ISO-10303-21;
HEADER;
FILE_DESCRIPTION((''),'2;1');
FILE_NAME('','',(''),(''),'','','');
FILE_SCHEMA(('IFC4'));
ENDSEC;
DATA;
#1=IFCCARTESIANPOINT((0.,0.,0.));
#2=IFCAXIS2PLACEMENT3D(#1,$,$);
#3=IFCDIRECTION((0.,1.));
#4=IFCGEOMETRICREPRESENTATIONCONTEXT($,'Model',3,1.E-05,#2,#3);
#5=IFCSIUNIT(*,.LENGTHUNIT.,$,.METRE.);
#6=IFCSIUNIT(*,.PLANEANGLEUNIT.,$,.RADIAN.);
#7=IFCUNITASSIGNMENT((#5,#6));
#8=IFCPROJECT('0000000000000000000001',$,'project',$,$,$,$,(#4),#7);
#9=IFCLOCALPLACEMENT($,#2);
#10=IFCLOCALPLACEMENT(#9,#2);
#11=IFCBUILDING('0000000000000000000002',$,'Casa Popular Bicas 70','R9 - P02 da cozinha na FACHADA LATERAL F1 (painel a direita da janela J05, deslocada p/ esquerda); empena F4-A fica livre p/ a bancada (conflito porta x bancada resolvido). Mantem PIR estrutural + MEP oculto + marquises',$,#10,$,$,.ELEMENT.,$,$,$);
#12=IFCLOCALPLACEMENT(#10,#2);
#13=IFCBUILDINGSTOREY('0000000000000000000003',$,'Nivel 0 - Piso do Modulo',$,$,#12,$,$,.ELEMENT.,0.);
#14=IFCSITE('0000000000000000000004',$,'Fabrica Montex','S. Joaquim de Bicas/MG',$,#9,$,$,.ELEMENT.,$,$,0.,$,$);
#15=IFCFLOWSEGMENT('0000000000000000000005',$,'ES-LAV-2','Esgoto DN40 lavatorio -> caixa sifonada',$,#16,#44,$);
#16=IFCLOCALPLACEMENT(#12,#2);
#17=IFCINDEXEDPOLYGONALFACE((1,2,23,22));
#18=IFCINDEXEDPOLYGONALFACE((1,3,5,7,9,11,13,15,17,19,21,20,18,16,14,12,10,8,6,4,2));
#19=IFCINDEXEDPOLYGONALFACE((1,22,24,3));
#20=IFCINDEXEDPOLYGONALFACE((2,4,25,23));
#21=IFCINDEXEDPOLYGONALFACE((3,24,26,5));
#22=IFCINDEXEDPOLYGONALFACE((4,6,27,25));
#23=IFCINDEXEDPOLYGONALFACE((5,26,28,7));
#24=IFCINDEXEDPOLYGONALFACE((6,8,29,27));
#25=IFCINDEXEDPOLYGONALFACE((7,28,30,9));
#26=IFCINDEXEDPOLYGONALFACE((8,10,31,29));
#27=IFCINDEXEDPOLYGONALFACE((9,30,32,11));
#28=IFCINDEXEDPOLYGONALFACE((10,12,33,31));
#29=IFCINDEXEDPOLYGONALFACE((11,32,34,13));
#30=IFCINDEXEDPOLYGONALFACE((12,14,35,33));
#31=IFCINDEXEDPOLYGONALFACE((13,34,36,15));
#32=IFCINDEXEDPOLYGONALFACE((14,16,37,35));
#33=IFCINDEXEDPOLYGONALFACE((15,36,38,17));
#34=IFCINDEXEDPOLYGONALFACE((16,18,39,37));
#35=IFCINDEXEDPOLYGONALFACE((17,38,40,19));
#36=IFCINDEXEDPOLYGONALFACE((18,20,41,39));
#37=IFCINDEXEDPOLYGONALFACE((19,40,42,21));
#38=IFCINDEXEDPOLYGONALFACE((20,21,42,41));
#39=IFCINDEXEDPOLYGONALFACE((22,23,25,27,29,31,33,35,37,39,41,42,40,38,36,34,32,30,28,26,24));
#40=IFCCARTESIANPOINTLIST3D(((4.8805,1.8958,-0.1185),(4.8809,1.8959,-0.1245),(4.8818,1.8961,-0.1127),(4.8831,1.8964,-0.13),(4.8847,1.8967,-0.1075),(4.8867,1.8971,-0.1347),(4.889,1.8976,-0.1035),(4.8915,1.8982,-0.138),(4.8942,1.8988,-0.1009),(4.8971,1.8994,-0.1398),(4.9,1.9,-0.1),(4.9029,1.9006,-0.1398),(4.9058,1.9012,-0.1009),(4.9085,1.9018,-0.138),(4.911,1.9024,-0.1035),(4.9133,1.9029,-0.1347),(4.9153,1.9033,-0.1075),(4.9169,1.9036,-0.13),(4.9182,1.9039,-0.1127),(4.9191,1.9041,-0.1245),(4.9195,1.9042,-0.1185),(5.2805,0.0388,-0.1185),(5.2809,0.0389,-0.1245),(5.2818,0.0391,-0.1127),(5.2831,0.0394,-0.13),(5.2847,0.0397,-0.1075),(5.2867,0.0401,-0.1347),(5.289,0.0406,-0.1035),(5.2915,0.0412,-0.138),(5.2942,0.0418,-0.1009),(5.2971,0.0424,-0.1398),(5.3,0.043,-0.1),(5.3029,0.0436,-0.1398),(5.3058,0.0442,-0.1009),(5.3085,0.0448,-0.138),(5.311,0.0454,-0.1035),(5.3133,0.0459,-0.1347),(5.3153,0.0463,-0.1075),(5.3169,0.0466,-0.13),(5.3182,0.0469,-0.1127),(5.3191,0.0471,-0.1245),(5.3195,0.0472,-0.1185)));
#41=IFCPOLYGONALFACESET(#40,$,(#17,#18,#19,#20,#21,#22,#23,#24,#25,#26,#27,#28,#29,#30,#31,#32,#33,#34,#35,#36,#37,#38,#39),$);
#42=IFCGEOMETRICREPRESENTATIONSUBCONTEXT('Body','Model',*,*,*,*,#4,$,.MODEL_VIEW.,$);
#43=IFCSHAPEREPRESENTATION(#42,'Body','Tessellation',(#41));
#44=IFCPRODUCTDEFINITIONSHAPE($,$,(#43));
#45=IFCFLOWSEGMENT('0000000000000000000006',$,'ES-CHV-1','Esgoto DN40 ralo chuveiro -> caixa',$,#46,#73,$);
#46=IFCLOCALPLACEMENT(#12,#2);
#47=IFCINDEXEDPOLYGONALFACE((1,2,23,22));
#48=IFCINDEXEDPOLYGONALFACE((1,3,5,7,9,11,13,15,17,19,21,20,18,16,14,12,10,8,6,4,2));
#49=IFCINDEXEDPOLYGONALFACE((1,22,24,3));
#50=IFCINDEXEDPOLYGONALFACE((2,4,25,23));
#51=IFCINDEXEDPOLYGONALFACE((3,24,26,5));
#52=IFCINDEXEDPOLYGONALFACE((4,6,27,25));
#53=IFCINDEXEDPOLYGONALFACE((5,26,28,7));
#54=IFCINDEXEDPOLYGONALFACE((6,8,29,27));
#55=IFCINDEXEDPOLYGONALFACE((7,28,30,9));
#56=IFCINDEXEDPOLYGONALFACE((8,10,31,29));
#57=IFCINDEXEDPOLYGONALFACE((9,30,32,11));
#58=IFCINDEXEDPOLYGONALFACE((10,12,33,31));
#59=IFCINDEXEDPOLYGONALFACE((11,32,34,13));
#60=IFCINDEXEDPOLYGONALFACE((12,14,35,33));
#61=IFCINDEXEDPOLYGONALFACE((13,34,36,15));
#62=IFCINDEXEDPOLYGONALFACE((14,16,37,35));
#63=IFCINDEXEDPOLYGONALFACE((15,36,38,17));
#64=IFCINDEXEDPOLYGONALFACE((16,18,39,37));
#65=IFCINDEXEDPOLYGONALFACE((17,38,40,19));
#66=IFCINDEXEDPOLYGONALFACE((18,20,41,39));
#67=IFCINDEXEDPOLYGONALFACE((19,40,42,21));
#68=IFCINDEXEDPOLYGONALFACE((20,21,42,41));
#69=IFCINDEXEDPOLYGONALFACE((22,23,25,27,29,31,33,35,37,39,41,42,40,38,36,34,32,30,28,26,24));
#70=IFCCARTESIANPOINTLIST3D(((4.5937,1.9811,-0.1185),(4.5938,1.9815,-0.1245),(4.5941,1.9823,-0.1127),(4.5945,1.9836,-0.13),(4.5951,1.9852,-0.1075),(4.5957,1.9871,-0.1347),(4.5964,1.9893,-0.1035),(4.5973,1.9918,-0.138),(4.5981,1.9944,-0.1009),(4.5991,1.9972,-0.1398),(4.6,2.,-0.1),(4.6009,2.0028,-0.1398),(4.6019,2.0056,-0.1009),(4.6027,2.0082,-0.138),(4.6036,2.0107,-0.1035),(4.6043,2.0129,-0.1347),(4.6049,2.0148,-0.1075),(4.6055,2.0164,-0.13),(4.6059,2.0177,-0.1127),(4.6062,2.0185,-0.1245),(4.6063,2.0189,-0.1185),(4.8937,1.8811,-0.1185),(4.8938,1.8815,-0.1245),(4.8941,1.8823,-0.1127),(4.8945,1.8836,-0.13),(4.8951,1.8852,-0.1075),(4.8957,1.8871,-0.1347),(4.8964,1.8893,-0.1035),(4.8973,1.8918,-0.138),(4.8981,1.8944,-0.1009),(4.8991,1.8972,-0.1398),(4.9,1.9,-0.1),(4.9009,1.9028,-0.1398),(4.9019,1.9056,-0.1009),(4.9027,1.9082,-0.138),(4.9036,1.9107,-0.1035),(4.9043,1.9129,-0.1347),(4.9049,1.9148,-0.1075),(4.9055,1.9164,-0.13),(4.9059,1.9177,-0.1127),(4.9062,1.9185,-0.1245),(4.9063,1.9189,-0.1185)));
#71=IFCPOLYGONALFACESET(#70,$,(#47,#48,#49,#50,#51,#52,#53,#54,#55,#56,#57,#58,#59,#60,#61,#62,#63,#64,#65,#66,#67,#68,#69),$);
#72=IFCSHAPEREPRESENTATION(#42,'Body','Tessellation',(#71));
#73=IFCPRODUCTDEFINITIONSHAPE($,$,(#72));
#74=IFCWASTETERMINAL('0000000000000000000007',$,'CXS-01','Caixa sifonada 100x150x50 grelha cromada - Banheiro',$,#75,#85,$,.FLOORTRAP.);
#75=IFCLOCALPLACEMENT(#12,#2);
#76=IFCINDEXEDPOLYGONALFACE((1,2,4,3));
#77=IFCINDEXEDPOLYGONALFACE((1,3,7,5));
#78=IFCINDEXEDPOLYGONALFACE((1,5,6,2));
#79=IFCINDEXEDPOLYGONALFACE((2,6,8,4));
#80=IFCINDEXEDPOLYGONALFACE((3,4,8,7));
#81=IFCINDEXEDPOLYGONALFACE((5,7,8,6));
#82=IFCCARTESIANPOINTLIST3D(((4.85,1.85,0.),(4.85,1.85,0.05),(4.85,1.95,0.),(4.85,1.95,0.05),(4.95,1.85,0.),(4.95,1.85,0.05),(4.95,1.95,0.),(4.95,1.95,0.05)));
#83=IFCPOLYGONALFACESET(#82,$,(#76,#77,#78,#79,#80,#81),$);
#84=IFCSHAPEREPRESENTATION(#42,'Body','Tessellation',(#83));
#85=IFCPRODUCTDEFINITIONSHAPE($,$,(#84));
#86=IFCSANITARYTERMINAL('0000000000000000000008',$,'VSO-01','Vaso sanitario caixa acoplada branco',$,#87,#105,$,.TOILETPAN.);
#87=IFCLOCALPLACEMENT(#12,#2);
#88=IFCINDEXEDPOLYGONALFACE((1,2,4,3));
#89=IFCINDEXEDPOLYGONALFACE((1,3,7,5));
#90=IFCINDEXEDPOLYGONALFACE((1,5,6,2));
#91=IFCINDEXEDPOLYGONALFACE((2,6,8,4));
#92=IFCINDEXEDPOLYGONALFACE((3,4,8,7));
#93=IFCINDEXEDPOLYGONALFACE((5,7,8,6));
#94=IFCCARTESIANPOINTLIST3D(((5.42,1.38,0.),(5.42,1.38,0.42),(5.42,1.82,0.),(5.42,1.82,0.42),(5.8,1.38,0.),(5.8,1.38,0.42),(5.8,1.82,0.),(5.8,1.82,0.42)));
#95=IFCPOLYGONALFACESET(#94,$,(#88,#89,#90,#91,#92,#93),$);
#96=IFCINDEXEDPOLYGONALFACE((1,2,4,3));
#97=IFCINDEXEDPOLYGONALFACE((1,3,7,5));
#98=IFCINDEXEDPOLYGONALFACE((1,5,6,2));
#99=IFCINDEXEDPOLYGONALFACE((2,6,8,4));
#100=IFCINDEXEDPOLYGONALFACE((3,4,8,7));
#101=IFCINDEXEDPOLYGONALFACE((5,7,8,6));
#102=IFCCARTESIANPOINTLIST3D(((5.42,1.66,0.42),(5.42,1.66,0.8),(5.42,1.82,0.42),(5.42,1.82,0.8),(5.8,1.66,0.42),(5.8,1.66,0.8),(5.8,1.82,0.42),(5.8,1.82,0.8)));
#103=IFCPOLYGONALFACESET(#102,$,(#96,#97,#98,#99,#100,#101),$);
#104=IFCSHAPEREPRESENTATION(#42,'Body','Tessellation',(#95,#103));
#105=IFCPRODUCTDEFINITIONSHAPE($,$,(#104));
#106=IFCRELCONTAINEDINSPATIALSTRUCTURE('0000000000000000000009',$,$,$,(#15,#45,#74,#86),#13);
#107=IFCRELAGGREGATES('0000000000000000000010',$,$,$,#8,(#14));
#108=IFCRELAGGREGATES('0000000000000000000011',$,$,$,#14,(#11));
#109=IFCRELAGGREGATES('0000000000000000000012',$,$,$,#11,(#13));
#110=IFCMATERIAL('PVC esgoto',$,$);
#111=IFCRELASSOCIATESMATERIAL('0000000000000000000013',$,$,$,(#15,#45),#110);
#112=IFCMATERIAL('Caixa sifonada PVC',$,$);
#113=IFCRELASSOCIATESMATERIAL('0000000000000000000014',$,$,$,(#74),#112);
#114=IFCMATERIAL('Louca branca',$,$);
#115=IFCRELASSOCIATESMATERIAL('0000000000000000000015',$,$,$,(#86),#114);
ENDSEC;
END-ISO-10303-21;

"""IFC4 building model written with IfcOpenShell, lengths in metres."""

from ifc_helpers import new_model, si_unit, direction, frame, frame_2d, origin, origin_2d, place, context, subcontext, project, spatial, rectangle, circle, extrude, material, element, save


model = new_model("IFC4")

# Units and contexts
model_context = context("Model", 3, precision=1e-05, world=origin(), true_north=direction((0.0, 1.0)))
body_context = subcontext(model_context, "Body", "Model", "MODEL_VIEW")
ifc_project = project(units=[si_unit("LENGTHUNIT", "METRE"), si_unit("PLANEANGLEUNIT", "RADIAN")], contexts=[model_context])

# Site, building, storey
site_placement = place(None, origin())
site = spatial("IfcSite", under=ifc_project, at=site_placement, Name="Fabrica Montex", Description="S. Joaquim de Bicas/MG", CompositionType="ELEMENT", RefElevation=0.0)
building_placement = place(site_placement, origin())
building = spatial("IfcBuilding", under=site, at=building_placement, Name="Casa Popular Bicas 70", Description="R9 - P02 da cozinha na FACHADA LATERAL F1 (painel a direita da janela J05, deslocada p/ esquerda); empena F4-A fica livre p/ a bancada (conflito porta x bancada resolvido). Mantem PIR estrutural + MEP oculto + marquises", CompositionType="ELEMENT")
storey_placement = place(building_placement, origin())
storey = spatial("IfcBuildingStorey", under=building, at=storey_placement, Name="Nivel 0 - Piso do Modulo", CompositionType="ELEMENT", Elevation=0.0)

# Flow segments
ifc_material_1 = material(Name="PVC esgoto")
flow_segment_1_placement = place(storey_placement, frame((5.3, 0.043, -0.12), z_axis=(-0.210572, 0.977578, 0.0), x_axis=(0.0, 0.0, 1.0)))
element("IfcFlowSegment", 1, at=flow_segment_1_placement, inside=storey, material=ifc_material_1, Name="ES-LAV-2", Description="Esgoto DN40 lavatorio -> caixa sifonada", context=body_context, shape_type="SweptSolid", body=[
    extrude(circle(Radius=0.02, at=origin_2d()), origin(), (0.0, 0.0, 1.0), 1.8996),
])
flow_segment_2_placement = place(storey_placement, frame((4.6, 2.0, -0.12), z_axis=(0.948683, -0.316228, 0.0), x_axis=(0.0, 0.0, 1.0)))
element("IfcFlowSegment", 2, at=flow_segment_2_placement, inside=storey, material=ifc_material_1, Name="ES-CHV-1", Description="Esgoto DN40 ralo chuveiro -> caixa", context=body_context, shape_type="SweptSolid", body=[
    extrude(circle(Radius=0.02, at=origin_2d()), origin(), (0.0, 0.0, 1.0), 0.3162),
])

# Waste terminal
ifc_material_2 = material(Name="Caixa sifonada PVC")
waste_terminal_placement = place(storey_placement, frame((4.85, 1.85, 0.0)))
element("IfcWasteTerminal", 3, at=waste_terminal_placement, inside=storey, material=ifc_material_2, Name="CXS-01", Description="Caixa sifonada 100x150x50 grelha cromada - Banheiro", PredefinedType="FLOORTRAP", context=body_context, shape_type="SweptSolid", body=[
    extrude(rectangle(XDim=0.1, YDim=0.1, at=frame_2d((0.05, 0.05))), origin(), (0.0, 0.0, 1.0), 0.05),
])

# Sanitary terminal
ifc_material_3 = material(Name="Louca branca")
sanitary_terminal_placement = place(storey_placement, frame((5.42, 1.38, 0.0)))
element("IfcSanitaryTerminal", 4, at=sanitary_terminal_placement, inside=storey, material=ifc_material_3, Name="VSO-01", Description="Vaso sanitario caixa acoplada branco", PredefinedType="TOILETPAN", context=body_context, shape_type="SweptSolid", body=[
    extrude(rectangle(XDim=0.38, YDim=0.44, at=frame_2d((0.19, 0.22))), origin(), (0.0, 0.0, 1.0), 0.42),
    extrude(rectangle(XDim=0.38, YDim=0.16, at=frame_2d((0.19, 0.36))), frame((0.0, 0.0, 0.42)), (0.0, 0.0, 1.0), 0.38),
])

save(model, "model.ifc")
